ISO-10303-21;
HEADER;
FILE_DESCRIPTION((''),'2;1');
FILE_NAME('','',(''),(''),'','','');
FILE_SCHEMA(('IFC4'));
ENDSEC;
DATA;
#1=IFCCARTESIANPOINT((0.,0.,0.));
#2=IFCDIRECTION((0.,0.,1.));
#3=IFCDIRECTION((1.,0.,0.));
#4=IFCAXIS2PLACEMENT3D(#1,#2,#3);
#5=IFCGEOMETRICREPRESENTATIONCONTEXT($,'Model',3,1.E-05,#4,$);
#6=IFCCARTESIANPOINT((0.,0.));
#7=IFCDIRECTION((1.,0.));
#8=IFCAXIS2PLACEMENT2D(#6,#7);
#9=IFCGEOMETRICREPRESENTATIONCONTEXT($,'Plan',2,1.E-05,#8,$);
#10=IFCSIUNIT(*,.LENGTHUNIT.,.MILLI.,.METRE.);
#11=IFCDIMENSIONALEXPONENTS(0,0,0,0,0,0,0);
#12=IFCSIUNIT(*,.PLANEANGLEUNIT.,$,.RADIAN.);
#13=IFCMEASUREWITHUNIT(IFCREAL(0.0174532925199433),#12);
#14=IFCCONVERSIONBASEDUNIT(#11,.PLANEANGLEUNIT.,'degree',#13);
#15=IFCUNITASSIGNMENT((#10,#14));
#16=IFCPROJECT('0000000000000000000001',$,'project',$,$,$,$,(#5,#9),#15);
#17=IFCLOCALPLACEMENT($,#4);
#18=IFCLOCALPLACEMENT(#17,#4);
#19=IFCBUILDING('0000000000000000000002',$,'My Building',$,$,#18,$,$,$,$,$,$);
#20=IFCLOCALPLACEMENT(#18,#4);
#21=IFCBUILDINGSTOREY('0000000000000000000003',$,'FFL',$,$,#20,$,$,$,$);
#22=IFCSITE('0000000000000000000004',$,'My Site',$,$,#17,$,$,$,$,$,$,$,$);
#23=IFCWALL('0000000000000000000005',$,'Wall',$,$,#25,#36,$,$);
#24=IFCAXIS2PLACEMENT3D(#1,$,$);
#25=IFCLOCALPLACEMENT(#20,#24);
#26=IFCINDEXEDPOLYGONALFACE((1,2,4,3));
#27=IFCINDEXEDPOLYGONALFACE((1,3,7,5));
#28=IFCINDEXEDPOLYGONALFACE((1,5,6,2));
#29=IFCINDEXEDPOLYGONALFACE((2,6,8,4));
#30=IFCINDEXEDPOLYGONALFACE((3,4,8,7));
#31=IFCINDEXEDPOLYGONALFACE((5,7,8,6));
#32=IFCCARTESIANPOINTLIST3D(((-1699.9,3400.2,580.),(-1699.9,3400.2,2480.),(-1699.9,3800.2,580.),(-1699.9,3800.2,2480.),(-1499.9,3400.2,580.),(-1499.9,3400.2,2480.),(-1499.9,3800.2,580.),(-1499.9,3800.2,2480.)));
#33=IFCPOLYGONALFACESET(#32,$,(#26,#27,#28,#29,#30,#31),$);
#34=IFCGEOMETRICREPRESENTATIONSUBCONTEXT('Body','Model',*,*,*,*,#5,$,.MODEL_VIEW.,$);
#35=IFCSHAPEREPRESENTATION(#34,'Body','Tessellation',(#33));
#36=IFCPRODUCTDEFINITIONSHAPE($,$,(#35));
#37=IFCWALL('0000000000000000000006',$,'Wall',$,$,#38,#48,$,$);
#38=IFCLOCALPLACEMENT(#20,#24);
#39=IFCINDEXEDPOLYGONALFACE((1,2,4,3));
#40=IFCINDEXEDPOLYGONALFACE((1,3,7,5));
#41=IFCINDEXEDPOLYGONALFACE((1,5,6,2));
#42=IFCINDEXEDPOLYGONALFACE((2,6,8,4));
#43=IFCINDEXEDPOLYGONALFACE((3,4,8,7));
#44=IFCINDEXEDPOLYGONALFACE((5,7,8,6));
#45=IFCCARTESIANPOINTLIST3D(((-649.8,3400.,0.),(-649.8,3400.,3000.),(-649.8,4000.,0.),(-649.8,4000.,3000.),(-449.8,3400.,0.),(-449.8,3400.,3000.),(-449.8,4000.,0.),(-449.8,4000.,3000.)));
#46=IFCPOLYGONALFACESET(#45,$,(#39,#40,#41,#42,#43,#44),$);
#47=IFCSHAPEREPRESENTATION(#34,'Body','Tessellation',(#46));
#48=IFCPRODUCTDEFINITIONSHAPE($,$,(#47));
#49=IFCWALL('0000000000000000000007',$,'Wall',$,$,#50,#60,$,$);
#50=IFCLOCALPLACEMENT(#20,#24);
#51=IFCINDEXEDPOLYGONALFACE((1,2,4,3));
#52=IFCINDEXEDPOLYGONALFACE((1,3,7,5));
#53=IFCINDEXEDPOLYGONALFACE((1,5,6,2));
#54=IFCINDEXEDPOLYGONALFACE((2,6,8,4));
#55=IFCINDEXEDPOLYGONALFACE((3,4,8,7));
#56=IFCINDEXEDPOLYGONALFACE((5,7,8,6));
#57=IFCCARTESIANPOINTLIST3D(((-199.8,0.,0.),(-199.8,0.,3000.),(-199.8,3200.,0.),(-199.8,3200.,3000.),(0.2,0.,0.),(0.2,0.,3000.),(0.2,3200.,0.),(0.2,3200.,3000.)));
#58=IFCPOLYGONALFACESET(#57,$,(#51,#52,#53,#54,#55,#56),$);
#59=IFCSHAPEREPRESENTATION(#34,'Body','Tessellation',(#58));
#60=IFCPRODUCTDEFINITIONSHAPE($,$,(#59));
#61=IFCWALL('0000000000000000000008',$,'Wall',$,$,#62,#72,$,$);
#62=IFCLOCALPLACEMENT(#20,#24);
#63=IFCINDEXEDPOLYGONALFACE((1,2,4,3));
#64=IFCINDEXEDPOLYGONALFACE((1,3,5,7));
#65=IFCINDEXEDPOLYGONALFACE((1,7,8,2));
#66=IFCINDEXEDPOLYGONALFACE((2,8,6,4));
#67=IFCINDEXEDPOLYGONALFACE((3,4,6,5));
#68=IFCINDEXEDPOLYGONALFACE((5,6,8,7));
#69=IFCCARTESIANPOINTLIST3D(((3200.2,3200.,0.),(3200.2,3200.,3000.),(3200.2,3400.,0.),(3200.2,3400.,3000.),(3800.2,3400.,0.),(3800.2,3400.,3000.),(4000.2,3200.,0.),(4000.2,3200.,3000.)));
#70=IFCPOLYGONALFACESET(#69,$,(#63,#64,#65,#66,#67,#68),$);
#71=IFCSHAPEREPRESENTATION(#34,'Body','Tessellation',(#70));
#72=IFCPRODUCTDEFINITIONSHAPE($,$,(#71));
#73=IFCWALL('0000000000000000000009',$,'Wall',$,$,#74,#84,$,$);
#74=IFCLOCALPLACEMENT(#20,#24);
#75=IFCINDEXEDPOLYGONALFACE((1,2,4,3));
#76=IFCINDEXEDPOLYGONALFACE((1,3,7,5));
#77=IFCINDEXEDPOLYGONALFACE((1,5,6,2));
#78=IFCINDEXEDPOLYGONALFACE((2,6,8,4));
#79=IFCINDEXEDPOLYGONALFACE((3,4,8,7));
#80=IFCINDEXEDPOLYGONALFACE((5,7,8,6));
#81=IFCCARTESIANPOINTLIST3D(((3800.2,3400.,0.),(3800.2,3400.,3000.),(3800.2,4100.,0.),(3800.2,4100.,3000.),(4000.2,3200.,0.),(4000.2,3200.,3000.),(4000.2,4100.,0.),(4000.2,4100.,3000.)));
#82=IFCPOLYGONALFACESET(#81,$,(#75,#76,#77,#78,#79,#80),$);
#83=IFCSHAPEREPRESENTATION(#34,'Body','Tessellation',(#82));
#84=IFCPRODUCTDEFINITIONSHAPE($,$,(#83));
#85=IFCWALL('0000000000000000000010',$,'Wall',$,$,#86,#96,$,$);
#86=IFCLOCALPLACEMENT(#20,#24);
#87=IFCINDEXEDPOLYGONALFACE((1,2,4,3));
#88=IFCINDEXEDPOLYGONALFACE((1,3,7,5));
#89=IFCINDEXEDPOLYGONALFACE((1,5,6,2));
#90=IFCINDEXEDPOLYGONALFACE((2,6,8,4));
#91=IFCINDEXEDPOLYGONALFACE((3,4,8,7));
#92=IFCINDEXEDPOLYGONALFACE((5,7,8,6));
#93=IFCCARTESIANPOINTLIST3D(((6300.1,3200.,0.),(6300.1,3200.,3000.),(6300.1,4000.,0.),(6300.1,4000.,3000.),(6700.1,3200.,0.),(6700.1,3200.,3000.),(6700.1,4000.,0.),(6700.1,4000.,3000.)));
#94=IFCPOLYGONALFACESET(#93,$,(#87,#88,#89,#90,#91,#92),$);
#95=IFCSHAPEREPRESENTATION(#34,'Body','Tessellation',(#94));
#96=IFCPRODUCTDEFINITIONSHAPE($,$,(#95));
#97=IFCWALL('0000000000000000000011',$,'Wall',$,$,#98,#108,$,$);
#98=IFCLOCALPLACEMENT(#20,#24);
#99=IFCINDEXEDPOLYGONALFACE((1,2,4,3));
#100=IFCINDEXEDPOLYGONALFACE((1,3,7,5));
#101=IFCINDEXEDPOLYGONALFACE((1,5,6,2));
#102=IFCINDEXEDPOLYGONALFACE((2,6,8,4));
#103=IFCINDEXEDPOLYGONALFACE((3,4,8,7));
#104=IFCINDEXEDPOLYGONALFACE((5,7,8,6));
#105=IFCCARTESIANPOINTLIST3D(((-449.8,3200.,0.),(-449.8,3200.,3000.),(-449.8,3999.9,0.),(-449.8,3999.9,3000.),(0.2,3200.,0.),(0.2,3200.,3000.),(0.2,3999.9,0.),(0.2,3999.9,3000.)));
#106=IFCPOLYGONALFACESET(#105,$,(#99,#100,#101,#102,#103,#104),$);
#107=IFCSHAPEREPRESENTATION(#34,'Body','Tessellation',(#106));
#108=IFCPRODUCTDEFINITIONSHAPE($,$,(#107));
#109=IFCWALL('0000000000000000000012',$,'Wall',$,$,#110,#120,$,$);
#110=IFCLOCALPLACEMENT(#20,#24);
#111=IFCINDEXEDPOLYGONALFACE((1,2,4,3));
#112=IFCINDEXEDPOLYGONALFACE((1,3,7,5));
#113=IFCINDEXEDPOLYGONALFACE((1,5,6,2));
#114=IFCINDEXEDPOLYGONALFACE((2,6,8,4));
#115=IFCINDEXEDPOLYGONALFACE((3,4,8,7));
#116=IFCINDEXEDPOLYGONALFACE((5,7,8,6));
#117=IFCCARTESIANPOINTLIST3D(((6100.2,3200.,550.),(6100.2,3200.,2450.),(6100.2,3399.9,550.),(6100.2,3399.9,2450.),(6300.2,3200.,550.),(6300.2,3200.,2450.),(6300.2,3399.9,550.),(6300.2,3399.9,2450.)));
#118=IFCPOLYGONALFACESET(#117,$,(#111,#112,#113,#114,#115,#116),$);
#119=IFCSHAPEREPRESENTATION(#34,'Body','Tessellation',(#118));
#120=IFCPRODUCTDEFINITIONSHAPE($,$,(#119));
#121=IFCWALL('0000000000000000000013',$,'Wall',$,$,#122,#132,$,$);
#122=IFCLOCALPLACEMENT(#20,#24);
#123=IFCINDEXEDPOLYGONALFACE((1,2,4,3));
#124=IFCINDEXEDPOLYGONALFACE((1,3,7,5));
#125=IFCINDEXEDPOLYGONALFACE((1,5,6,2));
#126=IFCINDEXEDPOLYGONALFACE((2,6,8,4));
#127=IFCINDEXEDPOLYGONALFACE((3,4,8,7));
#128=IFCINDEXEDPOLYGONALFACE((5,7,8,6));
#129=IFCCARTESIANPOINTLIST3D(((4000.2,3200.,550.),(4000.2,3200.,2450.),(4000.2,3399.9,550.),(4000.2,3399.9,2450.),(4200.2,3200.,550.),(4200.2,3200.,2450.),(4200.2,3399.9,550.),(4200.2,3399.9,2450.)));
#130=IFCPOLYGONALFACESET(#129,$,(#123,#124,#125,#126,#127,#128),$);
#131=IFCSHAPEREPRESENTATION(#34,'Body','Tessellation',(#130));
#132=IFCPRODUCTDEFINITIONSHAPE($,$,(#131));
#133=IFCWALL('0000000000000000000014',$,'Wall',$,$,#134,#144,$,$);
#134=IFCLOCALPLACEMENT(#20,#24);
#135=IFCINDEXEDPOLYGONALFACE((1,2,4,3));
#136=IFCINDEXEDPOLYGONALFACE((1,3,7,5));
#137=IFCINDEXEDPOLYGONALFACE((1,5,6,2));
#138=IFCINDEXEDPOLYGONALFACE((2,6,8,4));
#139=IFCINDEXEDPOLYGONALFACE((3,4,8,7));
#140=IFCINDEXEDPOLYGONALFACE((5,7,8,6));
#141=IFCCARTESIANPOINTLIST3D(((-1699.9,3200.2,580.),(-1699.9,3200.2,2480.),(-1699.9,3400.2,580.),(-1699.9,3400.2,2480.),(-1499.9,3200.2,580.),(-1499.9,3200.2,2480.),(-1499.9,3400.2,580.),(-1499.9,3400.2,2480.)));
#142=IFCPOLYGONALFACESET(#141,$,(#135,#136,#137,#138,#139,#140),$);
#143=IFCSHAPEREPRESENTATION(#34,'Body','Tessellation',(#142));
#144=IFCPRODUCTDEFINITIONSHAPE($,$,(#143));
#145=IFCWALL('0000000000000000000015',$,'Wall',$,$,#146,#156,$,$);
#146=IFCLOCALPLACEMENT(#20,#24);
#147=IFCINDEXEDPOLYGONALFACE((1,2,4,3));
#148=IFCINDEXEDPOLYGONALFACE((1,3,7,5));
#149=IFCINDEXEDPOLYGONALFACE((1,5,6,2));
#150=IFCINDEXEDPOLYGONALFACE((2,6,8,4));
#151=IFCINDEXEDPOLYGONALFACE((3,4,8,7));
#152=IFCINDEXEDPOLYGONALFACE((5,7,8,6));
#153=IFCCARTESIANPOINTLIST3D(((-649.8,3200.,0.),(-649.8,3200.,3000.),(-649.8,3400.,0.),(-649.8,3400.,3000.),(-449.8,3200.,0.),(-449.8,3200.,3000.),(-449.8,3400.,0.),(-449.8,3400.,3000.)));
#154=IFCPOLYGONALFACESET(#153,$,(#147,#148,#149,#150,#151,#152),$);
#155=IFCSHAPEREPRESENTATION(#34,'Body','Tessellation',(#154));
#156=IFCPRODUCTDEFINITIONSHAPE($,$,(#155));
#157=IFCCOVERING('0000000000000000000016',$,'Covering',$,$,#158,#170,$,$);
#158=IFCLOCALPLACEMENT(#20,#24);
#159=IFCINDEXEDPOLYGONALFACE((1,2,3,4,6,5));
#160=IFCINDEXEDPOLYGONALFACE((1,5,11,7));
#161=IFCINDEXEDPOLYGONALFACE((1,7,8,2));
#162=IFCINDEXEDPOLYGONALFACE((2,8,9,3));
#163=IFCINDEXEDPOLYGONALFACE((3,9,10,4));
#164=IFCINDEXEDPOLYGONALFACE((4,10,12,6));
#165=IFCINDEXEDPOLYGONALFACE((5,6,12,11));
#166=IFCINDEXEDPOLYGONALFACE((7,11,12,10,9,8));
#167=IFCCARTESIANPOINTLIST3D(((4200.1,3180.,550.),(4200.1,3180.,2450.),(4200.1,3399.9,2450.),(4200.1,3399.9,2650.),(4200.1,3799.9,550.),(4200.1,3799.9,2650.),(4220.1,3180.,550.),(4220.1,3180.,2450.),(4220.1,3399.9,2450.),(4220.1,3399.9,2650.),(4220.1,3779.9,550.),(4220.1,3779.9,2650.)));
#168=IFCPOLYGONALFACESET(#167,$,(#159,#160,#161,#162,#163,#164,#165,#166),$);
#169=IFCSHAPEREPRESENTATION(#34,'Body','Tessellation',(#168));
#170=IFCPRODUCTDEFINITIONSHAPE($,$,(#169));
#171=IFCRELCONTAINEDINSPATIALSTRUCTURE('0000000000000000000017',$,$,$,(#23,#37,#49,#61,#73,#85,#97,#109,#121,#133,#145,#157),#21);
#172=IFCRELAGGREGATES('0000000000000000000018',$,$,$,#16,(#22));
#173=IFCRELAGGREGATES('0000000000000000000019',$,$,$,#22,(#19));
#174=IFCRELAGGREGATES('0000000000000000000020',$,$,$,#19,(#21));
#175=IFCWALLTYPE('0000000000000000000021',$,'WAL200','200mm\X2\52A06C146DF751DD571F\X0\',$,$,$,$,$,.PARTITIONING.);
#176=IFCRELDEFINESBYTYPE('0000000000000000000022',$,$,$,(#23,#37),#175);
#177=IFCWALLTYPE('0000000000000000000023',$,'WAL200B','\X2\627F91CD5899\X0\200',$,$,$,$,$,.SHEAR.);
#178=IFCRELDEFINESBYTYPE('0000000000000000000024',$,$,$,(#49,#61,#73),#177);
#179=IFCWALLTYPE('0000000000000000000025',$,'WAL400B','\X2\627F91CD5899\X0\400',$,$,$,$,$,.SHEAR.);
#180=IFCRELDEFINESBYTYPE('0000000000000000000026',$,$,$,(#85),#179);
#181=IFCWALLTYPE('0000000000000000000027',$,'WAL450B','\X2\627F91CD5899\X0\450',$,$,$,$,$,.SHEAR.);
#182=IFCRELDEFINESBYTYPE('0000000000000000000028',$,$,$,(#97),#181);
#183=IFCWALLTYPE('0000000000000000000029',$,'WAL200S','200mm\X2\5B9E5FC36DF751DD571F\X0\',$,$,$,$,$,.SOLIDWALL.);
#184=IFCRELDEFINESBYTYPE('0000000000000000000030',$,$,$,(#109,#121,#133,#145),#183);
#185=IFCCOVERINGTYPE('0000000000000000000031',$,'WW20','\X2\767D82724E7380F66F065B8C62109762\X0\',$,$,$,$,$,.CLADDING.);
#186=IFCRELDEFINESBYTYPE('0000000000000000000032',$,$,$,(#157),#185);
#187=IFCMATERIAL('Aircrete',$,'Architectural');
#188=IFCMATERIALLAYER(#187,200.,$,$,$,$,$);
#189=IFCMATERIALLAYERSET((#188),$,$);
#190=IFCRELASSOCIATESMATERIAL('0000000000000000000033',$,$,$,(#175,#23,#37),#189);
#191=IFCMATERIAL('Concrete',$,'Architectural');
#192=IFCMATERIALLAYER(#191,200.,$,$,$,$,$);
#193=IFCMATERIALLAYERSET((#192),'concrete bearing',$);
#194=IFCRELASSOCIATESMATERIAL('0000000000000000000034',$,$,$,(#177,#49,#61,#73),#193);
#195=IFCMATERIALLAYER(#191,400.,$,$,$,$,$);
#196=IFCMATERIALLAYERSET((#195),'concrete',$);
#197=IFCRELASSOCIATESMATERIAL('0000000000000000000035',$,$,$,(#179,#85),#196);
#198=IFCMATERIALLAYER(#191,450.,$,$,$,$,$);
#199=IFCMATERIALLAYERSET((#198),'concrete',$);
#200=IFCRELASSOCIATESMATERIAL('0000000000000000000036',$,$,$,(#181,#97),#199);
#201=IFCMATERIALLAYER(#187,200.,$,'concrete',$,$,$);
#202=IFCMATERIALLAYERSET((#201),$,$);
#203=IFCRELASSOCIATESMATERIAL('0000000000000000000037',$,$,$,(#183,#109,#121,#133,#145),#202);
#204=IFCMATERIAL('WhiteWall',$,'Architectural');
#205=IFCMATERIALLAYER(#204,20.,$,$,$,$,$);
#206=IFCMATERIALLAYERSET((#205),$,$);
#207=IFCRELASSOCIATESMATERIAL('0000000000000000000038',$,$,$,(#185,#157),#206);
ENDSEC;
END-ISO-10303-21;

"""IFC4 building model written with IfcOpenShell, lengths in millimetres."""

from ifc_helpers import new_model, entity, si_unit, converted_unit, frame, origin_with_axes, origin_2d_with_axis, place, context, subcontext, project, spatial, line, indexed_curve, outline, extrude, material, layer, layer_set, layer_usage, type_object, element, save


model = new_model("IFC4")

# Units and contexts
model_context = context("Model", 3, precision=1e-05, world=origin_with_axes())
plan_context = context("Plan", 2, precision=1e-05, world=origin_2d_with_axis())
body_context_1 = subcontext(model_context, "Body", "Model", "MODEL_VIEW")
ifc_project = project(units=[si_unit("LENGTHUNIT", "METRE", prefix="MILLI"), converted_unit("PLANEANGLEUNIT", "degree", entity("IfcReal", 0.0174532925199433), si_unit("PLANEANGLEUNIT", "RADIAN"), dimensions=[0, 0, 0, 0, 0, 0, 0])], contexts=[model_context, plan_context])

# Site, building, storey
site_placement = place(None, origin_with_axes())
site = spatial("IfcSite", under=ifc_project, at=site_placement, Name="My Site")
building_placement = place(site_placement, origin_with_axes())
building = spatial("IfcBuilding", under=site, at=building_placement, Name="My Building")
storey_placement = place(building_placement, origin_with_axes())
storey = spatial("IfcBuildingStorey", under=building, at=storey_placement, Name="FFL")

# Shared definitions
ifc_material_1 = material(Name="Aircrete", Category="Architectural")

# Shared definitions
ifc_layer_1 = layer(ifc_material_1, 200.0)
ifc_layer_set_1 = layer_set([ifc_layer_1])
wall_type_1 = type_object("IfcWallType", Name="WAL200", Description="200mm加气混凝土", PredefinedType="PARTITIONING", material=ifc_layer_set_1)

# Walls
ifc_layer_usage_1 = layer_usage(ifc_layer_set_1, "AXIS2", "NEGATIVE", 0.0)
wall_1_placement = place(storey_placement, frame((-1699.9, 3400.2, 580.0), z_axis=(0.0, 0.0, 1.0), x_axis=(0.0, 1.0, 0.0)))
element("IfcWall", 1, at=wall_1_placement, inside=storey, type_object=wall_type_1, material=ifc_layer_usage_1, Name="Wall", context=body_context_1, shape_type="SweptSolid", body=[
    extrude(outline(indexed_curve([(0.0, -200.0), (0.0, 0.0), (400.0, 0.0), (400.0, -200.0)], segments=[line(1, 2, 3, 4, 1)])), origin_with_axes(), (0.0, 0.0, 1.0), 1900.0),
])
ifc_layer_usage_2 = layer_usage(ifc_layer_set_1, "AXIS2", "NEGATIVE", 0.0)
wall_2_placement = place(storey_placement, frame((-649.8, 3400.0, 0.0), z_axis=(0.0, 0.0, 1.0), x_axis=(0.0, 1.0, 0.0)))
element("IfcWall", 2, at=wall_2_placement, inside=storey, type_object=wall_type_1, material=ifc_layer_usage_2, Name="Wall", context=body_context_1, shape_type="SweptSolid", body=[
    extrude(outline(indexed_curve([(0.0, -200.0), (0.0, 0.0), (600.0, 0.0), (600.0, -200.0)], segments=[line(1, 2, 3, 4, 1)])), origin_with_axes(), (0.0, 0.0, 1.0), 3000.0),
])
ifc_material_2 = material(Name="Concrete", Category="Architectural")
ifc_layer_2 = layer(ifc_material_2, 200.0)
ifc_layer_set_2 = layer_set([ifc_layer_2], Name="concrete bearing")
ifc_layer_usage_3 = layer_usage(ifc_layer_set_2, "AXIS2", "NEGATIVE", 0.0)
wall_type_2 = type_object("IfcWallType", Name="WAL200B", Description="承重墙200", PredefinedType="SHEAR", material=ifc_layer_set_2)
wall_3_placement = place(storey_placement, frame((0.2, 3200.0, 0.0), z_axis=(0.0, 0.0, 1.0), x_axis=(0.0, -1.0, 0.0)))
element("IfcWall", 3, at=wall_3_placement, inside=storey, type_object=wall_type_2, material=ifc_layer_usage_3, Name="Wall", context=body_context_1, shape_type="SweptSolid", body=[
    extrude(outline(indexed_curve([(0.0, -200.0), (0.0, 0.0), (3200.0, 0.0), (3200.0, -200.0)], segments=[line(1, 2, 3, 4, 1)])), origin_with_axes(), (0.0, 0.0, 1.0), 3000.0),
])
ifc_layer_usage_4 = layer_usage(ifc_layer_set_2, "AXIS2", "NEGATIVE", 0.0)
wall_4_placement = place(storey_placement, frame((3800.2, 3200.0, 0.0), z_axis=(0.0, 0.0, 1.0), x_axis=(-1.0, 0.0, 0.0)))
element("IfcWall", 4, at=wall_4_placement, inside=storey, type_object=wall_type_2, material=ifc_layer_usage_4, Name="Wall", context=body_context_1, shape_type="SweptSolid", body=[
    extrude(outline(indexed_curve([(0.0, -200.0), (-200.0, 0.0), (600.0, 0.0), (600.0, -200.0)], segments=[line(1, 2, 3, 4, 1)])), origin_with_axes(), (0.0, 0.0, 1.0), 3000.0),
])
ifc_layer_usage_5 = layer_usage(ifc_layer_set_2, "AXIS2", "NEGATIVE", 0.0)
wall_5_placement = place(storey_placement, frame((3800.2, 3200.0, 0.0), z_axis=(0.0, 0.0, 1.0), x_axis=(0.0, 1.0, 0.0)))
element("IfcWall", 5, at=wall_5_placement, inside=storey, type_object=wall_type_2, material=ifc_layer_usage_5, Name="Wall", context=body_context_1, shape_type="SweptSolid", body=[
    extrude(outline(indexed_curve([(0.0, -200.0), (200.0, 0.0), (900.0, 0.0), (900.0, -200.0)], segments=[line(1, 2, 3, 4, 1)])), origin_with_axes(), (0.0, 0.0, 1.0), 3000.0),
])
ifc_layer_3 = layer(ifc_material_2, 400.0)
ifc_layer_set_3 = layer_set([ifc_layer_3], Name="concrete")
ifc_layer_usage_6 = layer_usage(ifc_layer_set_3, "AXIS2", "POSITIVE", 0.0)
wall_type_3 = type_object("IfcWallType", Name="WAL400B", Description="承重墙400", PredefinedType="SHEAR", material=ifc_layer_set_3)
wall_6_placement = place(storey_placement, frame((6700.1, 3200.0, 0.0), z_axis=(0.0, 0.0, 1.0), x_axis=(0.000001, 1.0, 0.0)))
element("IfcWall", 6, at=wall_6_placement, inside=storey, type_object=wall_type_3, material=ifc_layer_usage_6, Name="Wall", context=body_context_1, shape_type="SweptSolid", body=[
    extrude(outline(indexed_curve([(0.0, 0.0), (0.0, 400.0), (800.0, 400.0), (800.0, 0.0)], segments=[line(1, 2, 3, 4, 1)])), origin_with_axes(), (0.0, 0.0, 1.0), 3000.0),
])
ifc_layer_4 = layer(ifc_material_2, 450.0)
ifc_layer_set_4 = layer_set([ifc_layer_4], Name="concrete")
ifc_layer_usage_7 = layer_usage(ifc_layer_set_4, "AXIS2", "POSITIVE", 0.0)
wall_type_4 = type_object("IfcWallType", Name="WAL450B", Description="承重墙450", PredefinedType="SHEAR", material=ifc_layer_set_4)
wall_7_placement = place(storey_placement, frame((0.2, 3200.0, 0.0), z_axis=(0.0, 0.0, 1.0), x_axis=(0.0, 1.0, 0.0)))
element("IfcWall", 7, at=wall_7_placement, inside=storey, type_object=wall_type_4, material=ifc_layer_usage_7, Name="Wall", context=body_context_1, shape_type="SweptSolid", body=[
    extrude(outline(indexed_curve([(0.0, 0.0), (0.0, 450.0), (799.9, 450.0), (799.9, 0.0)], segments=[line(1, 2, 3, 4, 1)])), origin_with_axes(), (0.0, 0.0, 1.0), 3000.0),
])
ifc_layer_5 = layer(ifc_material_1, 200.0, Name="concrete")
ifc_layer_set_5 = layer_set([ifc_layer_5])
ifc_layer_usage_8 = layer_usage(ifc_layer_set_5, "AXIS2", "NEGATIVE", 0.0)
wall_type_5 = type_object("IfcWallType", Name="WAL200S", Description="200mm实心混凝土", PredefinedType="SOLIDWALL", material=ifc_layer_set_5)
wall_8_placement = place(storey_placement, frame((6100.2, 3200.0, 550.0), z_axis=(0.0, 0.0, 1.0), x_axis=(-0.000002, 1.0, 0.0)))
element("IfcWall", 8, at=wall_8_placement, inside=storey, type_object=wall_type_5, material=ifc_layer_usage_8, Name="Wall", context=body_context_1, shape_type="SweptSolid", body=[
    extrude(outline(indexed_curve([(0.0, -200.0), (0.0, 0.0), (200.0, 0.0), (200.0, -200.0)], segments=[line(1, 2, 3, 4, 1)])), origin_with_axes(), (0.0, 0.0, 1.0), 1900.0),
])
ifc_layer_usage_9 = layer_usage(ifc_layer_set_5, "AXIS2", "NEGATIVE", 0.0)
wall_9_placement = place(storey_placement, frame((4200.2, 3399.9, 550.0), z_axis=(0.0, 0.0, 1.0), x_axis=(0.000002, -1.0, 0.0)))
element("IfcWall", 9, at=wall_9_placement, inside=storey, type_object=wall_type_5, material=ifc_layer_usage_9, Name="Wall", context=body_context_1, shape_type="SweptSolid", body=[
    extrude(outline(indexed_curve([(0.0, -200.0), (0.0, 0.0), (200.0, 0.0), (200.0, -200.0)], segments=[line(1, 2, 3, 4, 1)])), origin_with_axes(), (0.0, 0.0, 1.0), 1900.0),
])
ifc_layer_usage_10 = layer_usage(ifc_layer_set_5, "AXIS2", "NEGATIVE", 0.0)
wall_10_placement = place(storey_placement, frame((-1699.9, 3200.2, 580.0), z_axis=(0.0, 0.0, 1.0), x_axis=(-0.000002, 1.0, 0.0)))
element("IfcWall", 10, at=wall_10_placement, inside=storey, type_object=wall_type_5, material=ifc_layer_usage_10, Name="Wall", context=body_context_1, shape_type="SweptSolid", body=[
    extrude(outline(indexed_curve([(0.0, -200.0), (0.0, 0.0), (200.0, 0.0), (200.0, -200.0)], segments=[line(1, 2, 3, 4, 1)])), origin_with_axes(), (0.0, 0.0, 1.0), 1900.0),
])
ifc_layer_usage_11 = layer_usage(ifc_layer_set_5, "AXIS2", "NEGATIVE", 0.0)
wall_11_placement = place(storey_placement, frame((-449.8, 3400.0, 0.0), z_axis=(0.0, 0.0, 1.0), x_axis=(0.000002, -1.0, 0.0)))
element("IfcWall", 11, at=wall_11_placement, inside=storey, type_object=wall_type_5, material=ifc_layer_usage_11, Name="Wall", context=body_context_1, shape_type="SweptSolid", body=[
    extrude(outline(indexed_curve([(0.0, -200.0), (0.0, 0.0), (200.0, 0.0), (200.0, -200.0)], segments=[line(1, 2, 3, 4, 1)])), origin_with_axes(), (0.0, 0.0, 1.0), 3000.0),
])

# Covering, opening
ifc_material_3 = material(Name="WhiteWall", Category="Architectural")
ifc_layer_6 = layer(ifc_material_3, 20.0)
ifc_layer_set_6 = layer_set([ifc_layer_6])
ifc_layer_usage_12 = layer_usage(ifc_layer_set_6, "AXIS2", "POSITIVE", 0.0)
covering_type_1 = type_object("IfcCoveringType", Name="WW20", Description="白色乳胶漆完成面", PredefinedType="CLADDING", material=ifc_layer_set_6)
covering_1_placement = place(storey_placement, frame((4200.1, 3799.9, 550.0), z_axis=(0.0, 0.0, 1.0), x_axis=(-0.000001, -1.0, 0.0)))
covering_1 = element("IfcCovering", 12, at=covering_1_placement, inside=storey, type_object=covering_type_1, material=ifc_layer_usage_12, Name="Covering", context=body_context_1, shape_type="SweptSolid", body=[
    extrude(outline(indexed_curve([(0.0, 0.0), (20.0, 20.0), (620.0, 20.0), (620.0, 0.0)], segments=[line(1, 2, 3, 4, 1)])), origin_with_axes(), (0.0, 0.0, 1.0), 2100.0),
])
opening_1_placement = place(covering_1_placement, frame((620.0, 120.0, 1900.0), z_axis=(0.000001, -1.0, 0.0), x_axis=(0.0, 0.0, 1.0)))
element("IfcOpeningElement", 13, at=opening_1_placement, cuts=covering_1, PredefinedType="OPENING", context=body_context_1, shape_type="SweptSolid", body=[
    extrude(outline(indexed_curve([(0.0, 220.0), (500.0, 220.0), (500.0, -100.0), (0.0, -100.0), (0.0, 220.0)])), origin_with_axes(), (0.0, 0.0, 1.0), 500.0),
])

save(model, "model.ifc")
